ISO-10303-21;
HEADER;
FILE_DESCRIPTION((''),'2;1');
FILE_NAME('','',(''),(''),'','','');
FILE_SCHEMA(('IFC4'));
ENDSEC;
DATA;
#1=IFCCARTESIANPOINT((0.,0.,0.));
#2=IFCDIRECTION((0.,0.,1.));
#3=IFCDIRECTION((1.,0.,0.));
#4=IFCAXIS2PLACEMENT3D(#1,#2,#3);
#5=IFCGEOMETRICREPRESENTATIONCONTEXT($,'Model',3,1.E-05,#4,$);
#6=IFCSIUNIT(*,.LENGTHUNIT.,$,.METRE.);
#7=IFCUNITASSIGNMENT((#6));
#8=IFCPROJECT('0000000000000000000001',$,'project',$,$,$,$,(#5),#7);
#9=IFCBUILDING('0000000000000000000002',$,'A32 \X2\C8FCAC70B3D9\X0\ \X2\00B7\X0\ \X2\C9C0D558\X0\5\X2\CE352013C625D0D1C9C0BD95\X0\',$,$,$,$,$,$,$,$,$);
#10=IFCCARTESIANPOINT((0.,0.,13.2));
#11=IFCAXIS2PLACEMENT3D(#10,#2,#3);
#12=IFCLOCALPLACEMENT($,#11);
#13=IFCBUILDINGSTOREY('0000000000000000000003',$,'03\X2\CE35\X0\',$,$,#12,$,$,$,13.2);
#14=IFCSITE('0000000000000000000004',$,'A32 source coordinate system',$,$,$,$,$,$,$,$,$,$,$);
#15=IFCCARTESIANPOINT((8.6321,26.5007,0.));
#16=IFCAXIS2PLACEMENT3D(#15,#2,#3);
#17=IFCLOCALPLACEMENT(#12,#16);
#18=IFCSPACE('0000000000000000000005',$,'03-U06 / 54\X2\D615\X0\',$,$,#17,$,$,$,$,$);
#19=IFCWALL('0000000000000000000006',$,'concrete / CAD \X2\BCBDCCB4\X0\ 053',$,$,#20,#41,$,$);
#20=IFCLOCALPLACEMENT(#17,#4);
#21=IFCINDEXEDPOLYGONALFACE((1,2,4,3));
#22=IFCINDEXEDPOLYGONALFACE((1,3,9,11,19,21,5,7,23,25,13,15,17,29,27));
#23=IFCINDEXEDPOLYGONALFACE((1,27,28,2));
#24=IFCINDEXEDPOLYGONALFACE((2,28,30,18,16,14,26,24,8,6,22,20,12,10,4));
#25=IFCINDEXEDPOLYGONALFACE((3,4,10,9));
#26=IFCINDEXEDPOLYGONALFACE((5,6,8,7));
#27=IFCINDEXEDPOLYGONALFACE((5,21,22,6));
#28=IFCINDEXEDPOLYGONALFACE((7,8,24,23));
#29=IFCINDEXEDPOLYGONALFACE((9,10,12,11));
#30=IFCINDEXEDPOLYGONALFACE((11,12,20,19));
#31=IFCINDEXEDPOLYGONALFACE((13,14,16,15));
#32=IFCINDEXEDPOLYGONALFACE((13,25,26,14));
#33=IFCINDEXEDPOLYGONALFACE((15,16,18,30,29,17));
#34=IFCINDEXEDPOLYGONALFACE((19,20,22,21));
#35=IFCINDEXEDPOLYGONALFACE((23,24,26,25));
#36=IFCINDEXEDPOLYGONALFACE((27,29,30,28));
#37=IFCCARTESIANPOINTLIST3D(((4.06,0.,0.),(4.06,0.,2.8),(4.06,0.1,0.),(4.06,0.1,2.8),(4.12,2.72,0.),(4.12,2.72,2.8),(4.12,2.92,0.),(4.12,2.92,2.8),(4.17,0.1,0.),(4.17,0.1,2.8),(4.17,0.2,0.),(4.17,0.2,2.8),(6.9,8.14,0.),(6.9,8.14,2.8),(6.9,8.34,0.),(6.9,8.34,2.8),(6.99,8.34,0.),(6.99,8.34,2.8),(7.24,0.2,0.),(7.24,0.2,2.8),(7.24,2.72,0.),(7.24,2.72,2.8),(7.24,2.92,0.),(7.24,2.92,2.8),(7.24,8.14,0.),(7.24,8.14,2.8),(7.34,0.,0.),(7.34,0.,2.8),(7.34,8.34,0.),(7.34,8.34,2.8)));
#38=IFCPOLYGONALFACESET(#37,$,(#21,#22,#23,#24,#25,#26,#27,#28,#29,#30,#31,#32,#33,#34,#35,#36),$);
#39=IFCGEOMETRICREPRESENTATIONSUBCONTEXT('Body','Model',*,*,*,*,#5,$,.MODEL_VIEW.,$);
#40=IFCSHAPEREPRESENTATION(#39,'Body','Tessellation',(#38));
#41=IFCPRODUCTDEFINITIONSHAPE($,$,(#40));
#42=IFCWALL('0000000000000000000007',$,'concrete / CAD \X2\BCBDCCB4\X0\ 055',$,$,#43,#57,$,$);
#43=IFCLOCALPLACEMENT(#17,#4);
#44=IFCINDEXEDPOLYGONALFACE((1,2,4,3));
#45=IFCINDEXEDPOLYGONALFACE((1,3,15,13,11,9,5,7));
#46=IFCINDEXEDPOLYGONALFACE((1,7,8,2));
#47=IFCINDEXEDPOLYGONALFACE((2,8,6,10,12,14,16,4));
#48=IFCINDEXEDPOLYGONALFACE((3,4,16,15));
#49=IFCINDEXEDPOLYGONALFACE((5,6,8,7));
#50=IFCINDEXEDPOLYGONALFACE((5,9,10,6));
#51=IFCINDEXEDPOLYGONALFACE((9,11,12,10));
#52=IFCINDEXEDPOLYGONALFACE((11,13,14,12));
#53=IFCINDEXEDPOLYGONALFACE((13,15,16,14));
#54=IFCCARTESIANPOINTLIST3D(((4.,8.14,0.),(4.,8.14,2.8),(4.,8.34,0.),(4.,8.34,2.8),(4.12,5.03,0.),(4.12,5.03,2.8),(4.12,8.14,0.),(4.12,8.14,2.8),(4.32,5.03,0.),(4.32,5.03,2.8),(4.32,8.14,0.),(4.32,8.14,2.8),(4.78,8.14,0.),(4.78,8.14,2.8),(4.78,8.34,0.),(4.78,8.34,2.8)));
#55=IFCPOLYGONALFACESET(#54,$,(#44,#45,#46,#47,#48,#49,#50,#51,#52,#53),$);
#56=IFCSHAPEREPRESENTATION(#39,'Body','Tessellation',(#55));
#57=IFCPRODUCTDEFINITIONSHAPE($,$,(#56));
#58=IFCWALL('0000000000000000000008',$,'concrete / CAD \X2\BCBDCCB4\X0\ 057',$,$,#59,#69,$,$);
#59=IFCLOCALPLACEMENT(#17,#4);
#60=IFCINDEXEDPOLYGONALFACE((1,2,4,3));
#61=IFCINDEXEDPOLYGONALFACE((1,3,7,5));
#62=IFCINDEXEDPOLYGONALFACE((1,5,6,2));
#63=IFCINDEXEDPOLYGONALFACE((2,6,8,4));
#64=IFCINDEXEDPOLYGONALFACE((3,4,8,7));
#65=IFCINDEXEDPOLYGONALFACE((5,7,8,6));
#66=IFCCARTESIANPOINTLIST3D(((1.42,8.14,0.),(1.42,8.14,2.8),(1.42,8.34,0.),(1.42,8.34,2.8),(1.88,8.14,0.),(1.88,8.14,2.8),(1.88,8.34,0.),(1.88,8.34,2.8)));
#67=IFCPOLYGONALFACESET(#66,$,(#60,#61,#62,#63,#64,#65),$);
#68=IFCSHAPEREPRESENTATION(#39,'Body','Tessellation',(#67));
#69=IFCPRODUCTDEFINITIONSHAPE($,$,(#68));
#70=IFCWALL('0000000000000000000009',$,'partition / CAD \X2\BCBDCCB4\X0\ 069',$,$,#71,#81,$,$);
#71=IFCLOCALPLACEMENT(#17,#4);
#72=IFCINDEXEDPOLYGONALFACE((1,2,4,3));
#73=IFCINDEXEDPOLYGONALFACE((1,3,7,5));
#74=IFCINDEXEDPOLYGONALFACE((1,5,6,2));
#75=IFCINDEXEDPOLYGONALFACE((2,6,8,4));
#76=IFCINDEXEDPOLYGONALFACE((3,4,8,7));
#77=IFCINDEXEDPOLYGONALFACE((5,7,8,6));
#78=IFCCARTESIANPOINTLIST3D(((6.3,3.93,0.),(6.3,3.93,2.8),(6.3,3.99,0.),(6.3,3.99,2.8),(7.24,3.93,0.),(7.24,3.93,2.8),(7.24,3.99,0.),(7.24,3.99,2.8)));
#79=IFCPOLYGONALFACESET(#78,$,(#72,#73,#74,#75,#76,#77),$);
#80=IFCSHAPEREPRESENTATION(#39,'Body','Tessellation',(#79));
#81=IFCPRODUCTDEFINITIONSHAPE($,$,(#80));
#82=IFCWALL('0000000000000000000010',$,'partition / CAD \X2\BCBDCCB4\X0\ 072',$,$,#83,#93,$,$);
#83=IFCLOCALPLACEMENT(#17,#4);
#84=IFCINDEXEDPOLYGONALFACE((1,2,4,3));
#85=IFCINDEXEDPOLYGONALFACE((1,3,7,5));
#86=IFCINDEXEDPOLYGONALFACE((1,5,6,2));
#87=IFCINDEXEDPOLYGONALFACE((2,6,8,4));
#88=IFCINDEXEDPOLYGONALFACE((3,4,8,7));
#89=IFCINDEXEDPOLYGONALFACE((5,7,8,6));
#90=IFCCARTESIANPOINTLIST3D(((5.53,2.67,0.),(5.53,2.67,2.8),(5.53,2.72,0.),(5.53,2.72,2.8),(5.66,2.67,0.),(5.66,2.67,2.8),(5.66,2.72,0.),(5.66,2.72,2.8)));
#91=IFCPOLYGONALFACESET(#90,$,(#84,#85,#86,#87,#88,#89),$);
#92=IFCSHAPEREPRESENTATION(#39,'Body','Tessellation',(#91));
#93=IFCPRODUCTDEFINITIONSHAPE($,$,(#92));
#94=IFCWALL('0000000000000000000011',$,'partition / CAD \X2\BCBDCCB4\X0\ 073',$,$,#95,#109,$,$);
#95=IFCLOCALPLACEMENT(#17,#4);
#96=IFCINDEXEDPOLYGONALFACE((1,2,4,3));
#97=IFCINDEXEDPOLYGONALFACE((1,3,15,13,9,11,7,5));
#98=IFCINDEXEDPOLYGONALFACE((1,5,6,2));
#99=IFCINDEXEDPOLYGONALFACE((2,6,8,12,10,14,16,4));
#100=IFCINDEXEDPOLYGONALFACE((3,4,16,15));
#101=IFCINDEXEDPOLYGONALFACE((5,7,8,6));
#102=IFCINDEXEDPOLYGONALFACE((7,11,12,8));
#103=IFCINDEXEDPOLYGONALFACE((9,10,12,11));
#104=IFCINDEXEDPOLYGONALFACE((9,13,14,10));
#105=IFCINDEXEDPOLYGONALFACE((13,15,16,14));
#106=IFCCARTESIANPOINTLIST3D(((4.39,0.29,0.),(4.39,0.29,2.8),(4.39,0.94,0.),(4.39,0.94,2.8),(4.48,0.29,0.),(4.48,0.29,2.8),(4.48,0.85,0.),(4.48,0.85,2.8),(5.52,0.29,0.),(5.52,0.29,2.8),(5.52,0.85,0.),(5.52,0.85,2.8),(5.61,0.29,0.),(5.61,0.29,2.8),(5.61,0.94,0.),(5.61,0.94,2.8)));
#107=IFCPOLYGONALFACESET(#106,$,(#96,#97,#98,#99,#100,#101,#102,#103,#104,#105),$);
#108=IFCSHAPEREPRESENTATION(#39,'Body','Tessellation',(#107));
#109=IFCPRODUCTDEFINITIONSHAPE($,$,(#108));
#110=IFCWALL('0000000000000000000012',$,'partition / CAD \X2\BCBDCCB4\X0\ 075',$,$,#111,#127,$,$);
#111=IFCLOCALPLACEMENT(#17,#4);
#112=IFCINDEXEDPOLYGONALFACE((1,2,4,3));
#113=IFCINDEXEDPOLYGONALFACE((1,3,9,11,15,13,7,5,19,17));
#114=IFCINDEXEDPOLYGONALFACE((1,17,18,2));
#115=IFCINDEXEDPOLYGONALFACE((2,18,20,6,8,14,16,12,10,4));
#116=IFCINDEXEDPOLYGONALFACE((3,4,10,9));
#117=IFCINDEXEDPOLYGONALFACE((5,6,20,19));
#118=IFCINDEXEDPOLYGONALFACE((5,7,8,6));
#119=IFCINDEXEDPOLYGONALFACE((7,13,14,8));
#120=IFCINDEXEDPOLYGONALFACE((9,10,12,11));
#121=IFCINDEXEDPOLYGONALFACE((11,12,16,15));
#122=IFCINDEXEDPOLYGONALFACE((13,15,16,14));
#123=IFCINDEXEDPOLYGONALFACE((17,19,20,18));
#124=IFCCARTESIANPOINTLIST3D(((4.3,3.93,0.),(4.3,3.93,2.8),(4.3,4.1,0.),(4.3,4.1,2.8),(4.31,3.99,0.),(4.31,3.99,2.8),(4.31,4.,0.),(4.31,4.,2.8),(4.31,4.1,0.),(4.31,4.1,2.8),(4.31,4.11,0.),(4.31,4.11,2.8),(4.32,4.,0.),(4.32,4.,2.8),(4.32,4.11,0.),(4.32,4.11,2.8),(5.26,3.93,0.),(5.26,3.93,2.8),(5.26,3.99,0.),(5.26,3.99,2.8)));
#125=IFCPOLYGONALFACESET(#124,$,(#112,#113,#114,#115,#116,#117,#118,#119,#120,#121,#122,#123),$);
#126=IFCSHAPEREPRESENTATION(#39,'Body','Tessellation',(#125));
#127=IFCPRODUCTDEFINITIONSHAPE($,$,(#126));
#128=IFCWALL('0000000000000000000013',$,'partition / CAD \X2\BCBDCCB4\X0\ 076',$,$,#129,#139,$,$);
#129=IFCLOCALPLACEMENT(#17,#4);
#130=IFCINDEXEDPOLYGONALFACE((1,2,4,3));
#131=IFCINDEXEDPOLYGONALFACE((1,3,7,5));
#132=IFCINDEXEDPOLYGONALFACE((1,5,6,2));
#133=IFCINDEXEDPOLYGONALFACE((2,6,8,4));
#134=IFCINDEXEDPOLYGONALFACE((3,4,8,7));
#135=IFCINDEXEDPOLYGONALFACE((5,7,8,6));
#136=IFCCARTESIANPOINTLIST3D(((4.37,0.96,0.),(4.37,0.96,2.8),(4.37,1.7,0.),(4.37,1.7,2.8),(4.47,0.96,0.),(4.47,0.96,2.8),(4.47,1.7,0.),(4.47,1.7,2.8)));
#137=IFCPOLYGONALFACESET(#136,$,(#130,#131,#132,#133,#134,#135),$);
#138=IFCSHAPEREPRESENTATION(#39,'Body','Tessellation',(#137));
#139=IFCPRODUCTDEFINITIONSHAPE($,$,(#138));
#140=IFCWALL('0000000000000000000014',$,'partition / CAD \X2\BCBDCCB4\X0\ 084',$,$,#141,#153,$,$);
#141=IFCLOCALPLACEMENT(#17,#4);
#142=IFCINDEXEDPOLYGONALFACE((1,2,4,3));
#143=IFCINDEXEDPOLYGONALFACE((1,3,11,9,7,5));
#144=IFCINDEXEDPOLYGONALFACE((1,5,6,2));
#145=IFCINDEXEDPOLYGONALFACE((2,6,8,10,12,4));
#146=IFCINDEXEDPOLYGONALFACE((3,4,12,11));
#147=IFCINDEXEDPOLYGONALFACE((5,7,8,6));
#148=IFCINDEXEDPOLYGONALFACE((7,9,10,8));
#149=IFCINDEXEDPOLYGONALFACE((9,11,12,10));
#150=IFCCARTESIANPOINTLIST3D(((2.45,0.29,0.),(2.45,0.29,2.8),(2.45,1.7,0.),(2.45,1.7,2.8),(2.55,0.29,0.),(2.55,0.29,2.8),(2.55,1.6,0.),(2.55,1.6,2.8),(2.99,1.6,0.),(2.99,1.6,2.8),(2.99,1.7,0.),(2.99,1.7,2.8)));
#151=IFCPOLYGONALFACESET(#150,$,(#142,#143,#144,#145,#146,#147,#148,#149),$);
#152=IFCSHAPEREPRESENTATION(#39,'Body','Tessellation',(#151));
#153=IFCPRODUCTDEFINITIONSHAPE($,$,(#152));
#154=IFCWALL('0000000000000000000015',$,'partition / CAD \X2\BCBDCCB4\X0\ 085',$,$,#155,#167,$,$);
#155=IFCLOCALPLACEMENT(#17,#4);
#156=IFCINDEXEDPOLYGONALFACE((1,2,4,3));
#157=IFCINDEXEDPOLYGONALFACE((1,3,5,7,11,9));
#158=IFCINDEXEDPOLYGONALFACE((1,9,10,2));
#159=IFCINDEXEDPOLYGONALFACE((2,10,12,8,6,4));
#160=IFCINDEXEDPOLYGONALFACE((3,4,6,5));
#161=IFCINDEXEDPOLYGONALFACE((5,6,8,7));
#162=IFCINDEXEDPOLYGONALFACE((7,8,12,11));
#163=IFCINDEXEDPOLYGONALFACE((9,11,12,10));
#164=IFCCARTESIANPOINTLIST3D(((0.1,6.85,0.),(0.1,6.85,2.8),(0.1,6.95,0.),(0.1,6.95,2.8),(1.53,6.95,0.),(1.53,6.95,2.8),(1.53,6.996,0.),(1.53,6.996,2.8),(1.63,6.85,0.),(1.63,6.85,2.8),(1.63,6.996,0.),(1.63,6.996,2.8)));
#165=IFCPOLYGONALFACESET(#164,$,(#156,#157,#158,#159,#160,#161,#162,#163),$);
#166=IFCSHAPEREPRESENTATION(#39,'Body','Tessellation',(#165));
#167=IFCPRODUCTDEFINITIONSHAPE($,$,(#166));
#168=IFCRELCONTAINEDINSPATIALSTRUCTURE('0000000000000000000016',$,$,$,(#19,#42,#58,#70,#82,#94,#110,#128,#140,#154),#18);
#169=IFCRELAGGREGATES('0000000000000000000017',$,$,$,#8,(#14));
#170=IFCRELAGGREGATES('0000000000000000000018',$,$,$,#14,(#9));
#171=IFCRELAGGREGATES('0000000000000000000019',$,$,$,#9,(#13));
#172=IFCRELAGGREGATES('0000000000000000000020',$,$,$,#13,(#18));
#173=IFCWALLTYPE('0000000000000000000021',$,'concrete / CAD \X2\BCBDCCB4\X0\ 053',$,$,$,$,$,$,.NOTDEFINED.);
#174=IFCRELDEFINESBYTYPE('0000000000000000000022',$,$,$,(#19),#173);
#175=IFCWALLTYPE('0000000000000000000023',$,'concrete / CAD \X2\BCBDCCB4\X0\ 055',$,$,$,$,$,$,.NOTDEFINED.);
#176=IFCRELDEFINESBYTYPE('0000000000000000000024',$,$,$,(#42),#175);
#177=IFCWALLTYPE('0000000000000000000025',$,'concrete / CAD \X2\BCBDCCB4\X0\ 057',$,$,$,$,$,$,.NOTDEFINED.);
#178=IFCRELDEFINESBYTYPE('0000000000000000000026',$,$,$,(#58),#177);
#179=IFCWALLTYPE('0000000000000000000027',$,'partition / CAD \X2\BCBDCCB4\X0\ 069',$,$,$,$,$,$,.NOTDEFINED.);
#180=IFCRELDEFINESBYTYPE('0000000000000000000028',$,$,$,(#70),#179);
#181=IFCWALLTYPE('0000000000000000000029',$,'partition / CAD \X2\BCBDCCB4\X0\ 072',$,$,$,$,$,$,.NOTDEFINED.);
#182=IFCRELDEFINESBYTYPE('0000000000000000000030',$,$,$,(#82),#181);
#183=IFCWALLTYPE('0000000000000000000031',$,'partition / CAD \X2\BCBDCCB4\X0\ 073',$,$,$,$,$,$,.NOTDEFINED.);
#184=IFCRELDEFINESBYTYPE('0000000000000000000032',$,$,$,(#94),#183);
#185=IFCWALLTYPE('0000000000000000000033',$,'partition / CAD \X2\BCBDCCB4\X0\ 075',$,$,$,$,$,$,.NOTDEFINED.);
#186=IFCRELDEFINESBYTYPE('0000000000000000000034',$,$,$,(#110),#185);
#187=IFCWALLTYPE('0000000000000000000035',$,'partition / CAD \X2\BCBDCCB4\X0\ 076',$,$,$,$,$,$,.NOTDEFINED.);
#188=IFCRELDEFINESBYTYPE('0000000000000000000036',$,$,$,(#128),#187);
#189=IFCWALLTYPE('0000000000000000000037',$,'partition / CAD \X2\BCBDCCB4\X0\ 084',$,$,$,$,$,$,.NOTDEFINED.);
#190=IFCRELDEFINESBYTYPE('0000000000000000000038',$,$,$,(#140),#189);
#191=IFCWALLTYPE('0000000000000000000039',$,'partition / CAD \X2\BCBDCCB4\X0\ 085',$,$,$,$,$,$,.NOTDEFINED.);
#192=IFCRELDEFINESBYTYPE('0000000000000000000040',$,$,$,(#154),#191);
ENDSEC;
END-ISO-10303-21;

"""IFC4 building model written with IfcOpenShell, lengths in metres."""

from ifc_helpers import new_model, si_unit, frame, origin, origin_with_axes, place, context, subcontext, project, spatial, polyline, outline, extrude, source, transform, mapped, type_object, type_shapes, element, save


model = new_model("IFC4")

# Units and contexts
model_context = context("Model", 3, precision=1e-05, world=origin_with_axes())
body_context = subcontext(model_context, "Body", "Model", "MODEL_VIEW")
ifc_project = project(units=[si_unit("LENGTHUNIT", "METRE")], contexts=[model_context])

# Site, building, storey, space
site = spatial("IfcSite", under=ifc_project, Name="A32 source coordinate system")
building = spatial("IfcBuilding", under=site, Name="A32 주거동 · 지하5층–옥탑지붕")
storey_placement = place(None, frame((0.0, 0.0, 13.2), z_axis=(0.0, 0.0, 1.0), x_axis=(1.0, 0.0, 0.0)))
storey = spatial("IfcBuildingStorey", under=building, at=storey_placement, Name="03층", Elevation=13.2)
space_placement = place(storey_placement, frame((8.6321, 26.5007, 0.0), z_axis=(0.0, 0.0, 1.0), x_axis=(1.0, 0.0, 0.0)))
space = spatial("IfcSpace", under=storey, at=space_placement, Name="03-U06 / 54형")

# Walls
wall_type_1 = type_object("IfcWallType", Name="concrete / CAD 벽체 053", PredefinedType="NOTDEFINED")
shared_shape_1 = source(origin(), body_context, "Body", "SweptSolid", [
    extrude(outline(polyline([(7.24, 8.14), (6.9, 8.14), (6.9, 8.34), (6.99, 8.34), (6.99, 8.34), (7.34, 8.34), (7.34, 8.34), (7.34, 0.0), (4.06, 0.0), (4.06, 0.1), (4.17, 0.1), (4.17, 0.2), (7.24, 0.2), (7.24, 2.72), (4.12, 2.72), (4.12, 2.92), (7.24, 2.92), (7.24, 8.14)])), origin(), (0.0, 0.0, 1.0), 2.8),
])
type_shapes(wall_type_1, [shared_shape_1])
wall_1_placement = place(space_placement, origin_with_axes())
element("IfcWall", 1, at=wall_1_placement, inside=space, type_object=wall_type_1, Name="concrete / CAD 벽체 053", context=body_context, shape_type="MappedRepresentation", body=[
    mapped(shared_shape_1, transform((0.0, 0.0, 0.0), scale=1.0)),
])
wall_type_2 = type_object("IfcWallType", Name="concrete / CAD 벽체 055", PredefinedType="NOTDEFINED")
shared_shape_2 = source(origin(), body_context, "Body", "SweptSolid", [
    extrude(outline(polyline([(4.32, 5.03), (4.12, 5.03), (4.12, 8.14), (4.0, 8.14), (4.0, 8.34), (4.78, 8.34), (4.78, 8.14), (4.32, 8.14), (4.32, 5.03)])), origin(), (0.0, 0.0, 1.0), 2.8),
])
type_shapes(wall_type_2, [shared_shape_2])
wall_2_placement = place(space_placement, origin_with_axes())
element("IfcWall", 2, at=wall_2_placement, inside=space, type_object=wall_type_2, Name="concrete / CAD 벽체 055", context=body_context, shape_type="MappedRepresentation", body=[
    mapped(shared_shape_2, transform((0.0, 0.0, 0.0), scale=1.0)),
])
wall_type_3 = type_object("IfcWallType", Name="concrete / CAD 벽체 057", PredefinedType="NOTDEFINED")
shared_shape_3 = source(origin(), body_context, "Body", "SweptSolid", [
    extrude(outline(polyline([(1.42, 8.14), (1.42, 8.34), (1.88, 8.34), (1.88, 8.14), (1.42, 8.14)])), origin(), (0.0, 0.0, 1.0), 2.8),
])
type_shapes(wall_type_3, [shared_shape_3])
wall_3_placement = place(space_placement, origin_with_axes())
element("IfcWall", 3, at=wall_3_placement, inside=space, type_object=wall_type_3, Name="concrete / CAD 벽체 057", context=body_context, shape_type="MappedRepresentation", body=[
    mapped(shared_shape_3, transform((0.0, 0.0, 0.0), scale=1.0)),
])
wall_type_4 = type_object("IfcWallType", Name="partition / CAD 벽체 069", PredefinedType="NOTDEFINED")
shared_shape_4 = source(origin(), body_context, "Body", "SweptSolid", [
    extrude(outline(polyline([(7.24, 3.93), (6.3, 3.93), (6.3, 3.99), (7.24, 3.99), (7.24, 3.93)])), origin(), (0.0, 0.0, 1.0), 2.8),
])
type_shapes(wall_type_4, [shared_shape_4])
wall_4_placement = place(space_placement, origin_with_axes())
element("IfcWall", 4, at=wall_4_placement, inside=space, type_object=wall_type_4, Name="partition / CAD 벽체 069", context=body_context, shape_type="MappedRepresentation", body=[
    mapped(shared_shape_4, transform((0.0, 0.0, 0.0), scale=1.0)),
])
wall_type_5 = type_object("IfcWallType", Name="partition / CAD 벽체 072", PredefinedType="NOTDEFINED")
shared_shape_5 = source(origin(), body_context, "Body", "SweptSolid", [
    extrude(outline(polyline([(5.66, 2.67), (5.53, 2.67), (5.53, 2.72), (5.66, 2.72), (5.66, 2.67)])), origin(), (0.0, 0.0, 1.0), 2.8),
])
type_shapes(wall_type_5, [shared_shape_5])
wall_5_placement = place(space_placement, origin_with_axes())
element("IfcWall", 5, at=wall_5_placement, inside=space, type_object=wall_type_5, Name="partition / CAD 벽체 072", context=body_context, shape_type="MappedRepresentation", body=[
    mapped(shared_shape_5, transform((0.0, 0.0, 0.0), scale=1.0)),
])
wall_type_6 = type_object("IfcWallType", Name="partition / CAD 벽체 073", PredefinedType="NOTDEFINED")
shared_shape_6 = source(origin(), body_context, "Body", "SweptSolid", [
    extrude(outline(polyline([(4.48, 0.29), (4.39, 0.29), (4.39, 0.94), (5.61, 0.94), (5.61, 0.29), (5.52, 0.29), (5.52, 0.85), (4.48, 0.85), (4.48, 0.29)])), origin(), (0.0, 0.0, 1.0), 2.8),
])
type_shapes(wall_type_6, [shared_shape_6])
wall_6_placement = place(space_placement, origin_with_axes())
element("IfcWall", 6, at=wall_6_placement, inside=space, type_object=wall_type_6, Name="partition / CAD 벽체 073", context=body_context, shape_type="MappedRepresentation", body=[
    mapped(shared_shape_6, transform((0.0, 0.0, 0.0), scale=1.0)),
])
wall_type_7 = type_object("IfcWallType", Name="partition / CAD 벽체 075", PredefinedType="NOTDEFINED")
shared_shape_7 = source(origin(), body_context, "Body", "SweptSolid", [
    extrude(outline(polyline([(4.32, 4.0), (4.31, 4.0), (4.31, 3.99), (5.26, 3.99), (5.26, 3.93), (4.3, 3.93), (4.3, 4.1), (4.31, 4.1), (4.31, 4.11), (4.32, 4.11), (4.32, 4.0)])), origin(), (0.0, 0.0, 1.0), 2.8),
])
type_shapes(wall_type_7, [shared_shape_7])
wall_7_placement = place(space_placement, origin_with_axes())
element("IfcWall", 7, at=wall_7_placement, inside=space, type_object=wall_type_7, Name="partition / CAD 벽체 075", context=body_context, shape_type="MappedRepresentation", body=[
    mapped(shared_shape_7, transform((0.0, 0.0, 0.0), scale=1.0)),
])
wall_type_8 = type_object("IfcWallType", Name="partition / CAD 벽체 076", PredefinedType="NOTDEFINED")
shared_shape_8 = source(origin(), body_context, "Body", "SweptSolid", [
    extrude(outline(polyline([(4.37, 1.7), (4.47, 1.7), (4.47, 0.96), (4.37, 0.96), (4.37, 1.7)])), origin(), (0.0, 0.0, 1.0), 2.8),
])
type_shapes(wall_type_8, [shared_shape_8])
wall_8_placement = place(space_placement, origin_with_axes())
element("IfcWall", 8, at=wall_8_placement, inside=space, type_object=wall_type_8, Name="partition / CAD 벽체 076", context=body_context, shape_type="MappedRepresentation", body=[
    mapped(shared_shape_8, transform((0.0, 0.0, 0.0), scale=1.0)),
])
wall_type_9 = type_object("IfcWallType", Name="partition / CAD 벽체 084", PredefinedType="NOTDEFINED")
shared_shape_9 = source(origin(), body_context, "Body", "SweptSolid", [
    extrude(outline(polyline([(2.99, 1.6), (2.55, 1.6), (2.55, 0.29), (2.45, 0.29), (2.45, 1.7), (2.99, 1.7), (2.99, 1.6)])), origin(), (0.0, 0.0, 1.0), 2.8),
])
type_shapes(wall_type_9, [shared_shape_9])
wall_9_placement = place(space_placement, origin_with_axes())
element("IfcWall", 9, at=wall_9_placement, inside=space, type_object=wall_type_9, Name="partition / CAD 벽체 084", context=body_context, shape_type="MappedRepresentation", body=[
    mapped(shared_shape_9, transform((0.0, 0.0, 0.0), scale=1.0)),
])
wall_type_10 = type_object("IfcWallType", Name="partition / CAD 벽체 085", PredefinedType="NOTDEFINED")
shared_shape_10 = source(origin(), body_context, "Body", "SweptSolid", [
    extrude(outline(polyline([(1.63, 6.85), (0.1, 6.85), (0.1, 6.95), (1.53, 6.95), (1.53, 6.996), (1.63, 6.996), (1.63, 6.85)])), origin(), (0.0, 0.0, 1.0), 2.8),
])
type_shapes(wall_type_10, [shared_shape_10])
wall_10_placement = place(space_placement, origin_with_axes())
element("IfcWall", 10, at=wall_10_placement, inside=space, type_object=wall_type_10, Name="partition / CAD 벽체 085", context=body_context, shape_type="MappedRepresentation", body=[
    mapped(shared_shape_10, transform((0.0, 0.0, 0.0), scale=1.0)),
])

save(model, "model.ifc")
